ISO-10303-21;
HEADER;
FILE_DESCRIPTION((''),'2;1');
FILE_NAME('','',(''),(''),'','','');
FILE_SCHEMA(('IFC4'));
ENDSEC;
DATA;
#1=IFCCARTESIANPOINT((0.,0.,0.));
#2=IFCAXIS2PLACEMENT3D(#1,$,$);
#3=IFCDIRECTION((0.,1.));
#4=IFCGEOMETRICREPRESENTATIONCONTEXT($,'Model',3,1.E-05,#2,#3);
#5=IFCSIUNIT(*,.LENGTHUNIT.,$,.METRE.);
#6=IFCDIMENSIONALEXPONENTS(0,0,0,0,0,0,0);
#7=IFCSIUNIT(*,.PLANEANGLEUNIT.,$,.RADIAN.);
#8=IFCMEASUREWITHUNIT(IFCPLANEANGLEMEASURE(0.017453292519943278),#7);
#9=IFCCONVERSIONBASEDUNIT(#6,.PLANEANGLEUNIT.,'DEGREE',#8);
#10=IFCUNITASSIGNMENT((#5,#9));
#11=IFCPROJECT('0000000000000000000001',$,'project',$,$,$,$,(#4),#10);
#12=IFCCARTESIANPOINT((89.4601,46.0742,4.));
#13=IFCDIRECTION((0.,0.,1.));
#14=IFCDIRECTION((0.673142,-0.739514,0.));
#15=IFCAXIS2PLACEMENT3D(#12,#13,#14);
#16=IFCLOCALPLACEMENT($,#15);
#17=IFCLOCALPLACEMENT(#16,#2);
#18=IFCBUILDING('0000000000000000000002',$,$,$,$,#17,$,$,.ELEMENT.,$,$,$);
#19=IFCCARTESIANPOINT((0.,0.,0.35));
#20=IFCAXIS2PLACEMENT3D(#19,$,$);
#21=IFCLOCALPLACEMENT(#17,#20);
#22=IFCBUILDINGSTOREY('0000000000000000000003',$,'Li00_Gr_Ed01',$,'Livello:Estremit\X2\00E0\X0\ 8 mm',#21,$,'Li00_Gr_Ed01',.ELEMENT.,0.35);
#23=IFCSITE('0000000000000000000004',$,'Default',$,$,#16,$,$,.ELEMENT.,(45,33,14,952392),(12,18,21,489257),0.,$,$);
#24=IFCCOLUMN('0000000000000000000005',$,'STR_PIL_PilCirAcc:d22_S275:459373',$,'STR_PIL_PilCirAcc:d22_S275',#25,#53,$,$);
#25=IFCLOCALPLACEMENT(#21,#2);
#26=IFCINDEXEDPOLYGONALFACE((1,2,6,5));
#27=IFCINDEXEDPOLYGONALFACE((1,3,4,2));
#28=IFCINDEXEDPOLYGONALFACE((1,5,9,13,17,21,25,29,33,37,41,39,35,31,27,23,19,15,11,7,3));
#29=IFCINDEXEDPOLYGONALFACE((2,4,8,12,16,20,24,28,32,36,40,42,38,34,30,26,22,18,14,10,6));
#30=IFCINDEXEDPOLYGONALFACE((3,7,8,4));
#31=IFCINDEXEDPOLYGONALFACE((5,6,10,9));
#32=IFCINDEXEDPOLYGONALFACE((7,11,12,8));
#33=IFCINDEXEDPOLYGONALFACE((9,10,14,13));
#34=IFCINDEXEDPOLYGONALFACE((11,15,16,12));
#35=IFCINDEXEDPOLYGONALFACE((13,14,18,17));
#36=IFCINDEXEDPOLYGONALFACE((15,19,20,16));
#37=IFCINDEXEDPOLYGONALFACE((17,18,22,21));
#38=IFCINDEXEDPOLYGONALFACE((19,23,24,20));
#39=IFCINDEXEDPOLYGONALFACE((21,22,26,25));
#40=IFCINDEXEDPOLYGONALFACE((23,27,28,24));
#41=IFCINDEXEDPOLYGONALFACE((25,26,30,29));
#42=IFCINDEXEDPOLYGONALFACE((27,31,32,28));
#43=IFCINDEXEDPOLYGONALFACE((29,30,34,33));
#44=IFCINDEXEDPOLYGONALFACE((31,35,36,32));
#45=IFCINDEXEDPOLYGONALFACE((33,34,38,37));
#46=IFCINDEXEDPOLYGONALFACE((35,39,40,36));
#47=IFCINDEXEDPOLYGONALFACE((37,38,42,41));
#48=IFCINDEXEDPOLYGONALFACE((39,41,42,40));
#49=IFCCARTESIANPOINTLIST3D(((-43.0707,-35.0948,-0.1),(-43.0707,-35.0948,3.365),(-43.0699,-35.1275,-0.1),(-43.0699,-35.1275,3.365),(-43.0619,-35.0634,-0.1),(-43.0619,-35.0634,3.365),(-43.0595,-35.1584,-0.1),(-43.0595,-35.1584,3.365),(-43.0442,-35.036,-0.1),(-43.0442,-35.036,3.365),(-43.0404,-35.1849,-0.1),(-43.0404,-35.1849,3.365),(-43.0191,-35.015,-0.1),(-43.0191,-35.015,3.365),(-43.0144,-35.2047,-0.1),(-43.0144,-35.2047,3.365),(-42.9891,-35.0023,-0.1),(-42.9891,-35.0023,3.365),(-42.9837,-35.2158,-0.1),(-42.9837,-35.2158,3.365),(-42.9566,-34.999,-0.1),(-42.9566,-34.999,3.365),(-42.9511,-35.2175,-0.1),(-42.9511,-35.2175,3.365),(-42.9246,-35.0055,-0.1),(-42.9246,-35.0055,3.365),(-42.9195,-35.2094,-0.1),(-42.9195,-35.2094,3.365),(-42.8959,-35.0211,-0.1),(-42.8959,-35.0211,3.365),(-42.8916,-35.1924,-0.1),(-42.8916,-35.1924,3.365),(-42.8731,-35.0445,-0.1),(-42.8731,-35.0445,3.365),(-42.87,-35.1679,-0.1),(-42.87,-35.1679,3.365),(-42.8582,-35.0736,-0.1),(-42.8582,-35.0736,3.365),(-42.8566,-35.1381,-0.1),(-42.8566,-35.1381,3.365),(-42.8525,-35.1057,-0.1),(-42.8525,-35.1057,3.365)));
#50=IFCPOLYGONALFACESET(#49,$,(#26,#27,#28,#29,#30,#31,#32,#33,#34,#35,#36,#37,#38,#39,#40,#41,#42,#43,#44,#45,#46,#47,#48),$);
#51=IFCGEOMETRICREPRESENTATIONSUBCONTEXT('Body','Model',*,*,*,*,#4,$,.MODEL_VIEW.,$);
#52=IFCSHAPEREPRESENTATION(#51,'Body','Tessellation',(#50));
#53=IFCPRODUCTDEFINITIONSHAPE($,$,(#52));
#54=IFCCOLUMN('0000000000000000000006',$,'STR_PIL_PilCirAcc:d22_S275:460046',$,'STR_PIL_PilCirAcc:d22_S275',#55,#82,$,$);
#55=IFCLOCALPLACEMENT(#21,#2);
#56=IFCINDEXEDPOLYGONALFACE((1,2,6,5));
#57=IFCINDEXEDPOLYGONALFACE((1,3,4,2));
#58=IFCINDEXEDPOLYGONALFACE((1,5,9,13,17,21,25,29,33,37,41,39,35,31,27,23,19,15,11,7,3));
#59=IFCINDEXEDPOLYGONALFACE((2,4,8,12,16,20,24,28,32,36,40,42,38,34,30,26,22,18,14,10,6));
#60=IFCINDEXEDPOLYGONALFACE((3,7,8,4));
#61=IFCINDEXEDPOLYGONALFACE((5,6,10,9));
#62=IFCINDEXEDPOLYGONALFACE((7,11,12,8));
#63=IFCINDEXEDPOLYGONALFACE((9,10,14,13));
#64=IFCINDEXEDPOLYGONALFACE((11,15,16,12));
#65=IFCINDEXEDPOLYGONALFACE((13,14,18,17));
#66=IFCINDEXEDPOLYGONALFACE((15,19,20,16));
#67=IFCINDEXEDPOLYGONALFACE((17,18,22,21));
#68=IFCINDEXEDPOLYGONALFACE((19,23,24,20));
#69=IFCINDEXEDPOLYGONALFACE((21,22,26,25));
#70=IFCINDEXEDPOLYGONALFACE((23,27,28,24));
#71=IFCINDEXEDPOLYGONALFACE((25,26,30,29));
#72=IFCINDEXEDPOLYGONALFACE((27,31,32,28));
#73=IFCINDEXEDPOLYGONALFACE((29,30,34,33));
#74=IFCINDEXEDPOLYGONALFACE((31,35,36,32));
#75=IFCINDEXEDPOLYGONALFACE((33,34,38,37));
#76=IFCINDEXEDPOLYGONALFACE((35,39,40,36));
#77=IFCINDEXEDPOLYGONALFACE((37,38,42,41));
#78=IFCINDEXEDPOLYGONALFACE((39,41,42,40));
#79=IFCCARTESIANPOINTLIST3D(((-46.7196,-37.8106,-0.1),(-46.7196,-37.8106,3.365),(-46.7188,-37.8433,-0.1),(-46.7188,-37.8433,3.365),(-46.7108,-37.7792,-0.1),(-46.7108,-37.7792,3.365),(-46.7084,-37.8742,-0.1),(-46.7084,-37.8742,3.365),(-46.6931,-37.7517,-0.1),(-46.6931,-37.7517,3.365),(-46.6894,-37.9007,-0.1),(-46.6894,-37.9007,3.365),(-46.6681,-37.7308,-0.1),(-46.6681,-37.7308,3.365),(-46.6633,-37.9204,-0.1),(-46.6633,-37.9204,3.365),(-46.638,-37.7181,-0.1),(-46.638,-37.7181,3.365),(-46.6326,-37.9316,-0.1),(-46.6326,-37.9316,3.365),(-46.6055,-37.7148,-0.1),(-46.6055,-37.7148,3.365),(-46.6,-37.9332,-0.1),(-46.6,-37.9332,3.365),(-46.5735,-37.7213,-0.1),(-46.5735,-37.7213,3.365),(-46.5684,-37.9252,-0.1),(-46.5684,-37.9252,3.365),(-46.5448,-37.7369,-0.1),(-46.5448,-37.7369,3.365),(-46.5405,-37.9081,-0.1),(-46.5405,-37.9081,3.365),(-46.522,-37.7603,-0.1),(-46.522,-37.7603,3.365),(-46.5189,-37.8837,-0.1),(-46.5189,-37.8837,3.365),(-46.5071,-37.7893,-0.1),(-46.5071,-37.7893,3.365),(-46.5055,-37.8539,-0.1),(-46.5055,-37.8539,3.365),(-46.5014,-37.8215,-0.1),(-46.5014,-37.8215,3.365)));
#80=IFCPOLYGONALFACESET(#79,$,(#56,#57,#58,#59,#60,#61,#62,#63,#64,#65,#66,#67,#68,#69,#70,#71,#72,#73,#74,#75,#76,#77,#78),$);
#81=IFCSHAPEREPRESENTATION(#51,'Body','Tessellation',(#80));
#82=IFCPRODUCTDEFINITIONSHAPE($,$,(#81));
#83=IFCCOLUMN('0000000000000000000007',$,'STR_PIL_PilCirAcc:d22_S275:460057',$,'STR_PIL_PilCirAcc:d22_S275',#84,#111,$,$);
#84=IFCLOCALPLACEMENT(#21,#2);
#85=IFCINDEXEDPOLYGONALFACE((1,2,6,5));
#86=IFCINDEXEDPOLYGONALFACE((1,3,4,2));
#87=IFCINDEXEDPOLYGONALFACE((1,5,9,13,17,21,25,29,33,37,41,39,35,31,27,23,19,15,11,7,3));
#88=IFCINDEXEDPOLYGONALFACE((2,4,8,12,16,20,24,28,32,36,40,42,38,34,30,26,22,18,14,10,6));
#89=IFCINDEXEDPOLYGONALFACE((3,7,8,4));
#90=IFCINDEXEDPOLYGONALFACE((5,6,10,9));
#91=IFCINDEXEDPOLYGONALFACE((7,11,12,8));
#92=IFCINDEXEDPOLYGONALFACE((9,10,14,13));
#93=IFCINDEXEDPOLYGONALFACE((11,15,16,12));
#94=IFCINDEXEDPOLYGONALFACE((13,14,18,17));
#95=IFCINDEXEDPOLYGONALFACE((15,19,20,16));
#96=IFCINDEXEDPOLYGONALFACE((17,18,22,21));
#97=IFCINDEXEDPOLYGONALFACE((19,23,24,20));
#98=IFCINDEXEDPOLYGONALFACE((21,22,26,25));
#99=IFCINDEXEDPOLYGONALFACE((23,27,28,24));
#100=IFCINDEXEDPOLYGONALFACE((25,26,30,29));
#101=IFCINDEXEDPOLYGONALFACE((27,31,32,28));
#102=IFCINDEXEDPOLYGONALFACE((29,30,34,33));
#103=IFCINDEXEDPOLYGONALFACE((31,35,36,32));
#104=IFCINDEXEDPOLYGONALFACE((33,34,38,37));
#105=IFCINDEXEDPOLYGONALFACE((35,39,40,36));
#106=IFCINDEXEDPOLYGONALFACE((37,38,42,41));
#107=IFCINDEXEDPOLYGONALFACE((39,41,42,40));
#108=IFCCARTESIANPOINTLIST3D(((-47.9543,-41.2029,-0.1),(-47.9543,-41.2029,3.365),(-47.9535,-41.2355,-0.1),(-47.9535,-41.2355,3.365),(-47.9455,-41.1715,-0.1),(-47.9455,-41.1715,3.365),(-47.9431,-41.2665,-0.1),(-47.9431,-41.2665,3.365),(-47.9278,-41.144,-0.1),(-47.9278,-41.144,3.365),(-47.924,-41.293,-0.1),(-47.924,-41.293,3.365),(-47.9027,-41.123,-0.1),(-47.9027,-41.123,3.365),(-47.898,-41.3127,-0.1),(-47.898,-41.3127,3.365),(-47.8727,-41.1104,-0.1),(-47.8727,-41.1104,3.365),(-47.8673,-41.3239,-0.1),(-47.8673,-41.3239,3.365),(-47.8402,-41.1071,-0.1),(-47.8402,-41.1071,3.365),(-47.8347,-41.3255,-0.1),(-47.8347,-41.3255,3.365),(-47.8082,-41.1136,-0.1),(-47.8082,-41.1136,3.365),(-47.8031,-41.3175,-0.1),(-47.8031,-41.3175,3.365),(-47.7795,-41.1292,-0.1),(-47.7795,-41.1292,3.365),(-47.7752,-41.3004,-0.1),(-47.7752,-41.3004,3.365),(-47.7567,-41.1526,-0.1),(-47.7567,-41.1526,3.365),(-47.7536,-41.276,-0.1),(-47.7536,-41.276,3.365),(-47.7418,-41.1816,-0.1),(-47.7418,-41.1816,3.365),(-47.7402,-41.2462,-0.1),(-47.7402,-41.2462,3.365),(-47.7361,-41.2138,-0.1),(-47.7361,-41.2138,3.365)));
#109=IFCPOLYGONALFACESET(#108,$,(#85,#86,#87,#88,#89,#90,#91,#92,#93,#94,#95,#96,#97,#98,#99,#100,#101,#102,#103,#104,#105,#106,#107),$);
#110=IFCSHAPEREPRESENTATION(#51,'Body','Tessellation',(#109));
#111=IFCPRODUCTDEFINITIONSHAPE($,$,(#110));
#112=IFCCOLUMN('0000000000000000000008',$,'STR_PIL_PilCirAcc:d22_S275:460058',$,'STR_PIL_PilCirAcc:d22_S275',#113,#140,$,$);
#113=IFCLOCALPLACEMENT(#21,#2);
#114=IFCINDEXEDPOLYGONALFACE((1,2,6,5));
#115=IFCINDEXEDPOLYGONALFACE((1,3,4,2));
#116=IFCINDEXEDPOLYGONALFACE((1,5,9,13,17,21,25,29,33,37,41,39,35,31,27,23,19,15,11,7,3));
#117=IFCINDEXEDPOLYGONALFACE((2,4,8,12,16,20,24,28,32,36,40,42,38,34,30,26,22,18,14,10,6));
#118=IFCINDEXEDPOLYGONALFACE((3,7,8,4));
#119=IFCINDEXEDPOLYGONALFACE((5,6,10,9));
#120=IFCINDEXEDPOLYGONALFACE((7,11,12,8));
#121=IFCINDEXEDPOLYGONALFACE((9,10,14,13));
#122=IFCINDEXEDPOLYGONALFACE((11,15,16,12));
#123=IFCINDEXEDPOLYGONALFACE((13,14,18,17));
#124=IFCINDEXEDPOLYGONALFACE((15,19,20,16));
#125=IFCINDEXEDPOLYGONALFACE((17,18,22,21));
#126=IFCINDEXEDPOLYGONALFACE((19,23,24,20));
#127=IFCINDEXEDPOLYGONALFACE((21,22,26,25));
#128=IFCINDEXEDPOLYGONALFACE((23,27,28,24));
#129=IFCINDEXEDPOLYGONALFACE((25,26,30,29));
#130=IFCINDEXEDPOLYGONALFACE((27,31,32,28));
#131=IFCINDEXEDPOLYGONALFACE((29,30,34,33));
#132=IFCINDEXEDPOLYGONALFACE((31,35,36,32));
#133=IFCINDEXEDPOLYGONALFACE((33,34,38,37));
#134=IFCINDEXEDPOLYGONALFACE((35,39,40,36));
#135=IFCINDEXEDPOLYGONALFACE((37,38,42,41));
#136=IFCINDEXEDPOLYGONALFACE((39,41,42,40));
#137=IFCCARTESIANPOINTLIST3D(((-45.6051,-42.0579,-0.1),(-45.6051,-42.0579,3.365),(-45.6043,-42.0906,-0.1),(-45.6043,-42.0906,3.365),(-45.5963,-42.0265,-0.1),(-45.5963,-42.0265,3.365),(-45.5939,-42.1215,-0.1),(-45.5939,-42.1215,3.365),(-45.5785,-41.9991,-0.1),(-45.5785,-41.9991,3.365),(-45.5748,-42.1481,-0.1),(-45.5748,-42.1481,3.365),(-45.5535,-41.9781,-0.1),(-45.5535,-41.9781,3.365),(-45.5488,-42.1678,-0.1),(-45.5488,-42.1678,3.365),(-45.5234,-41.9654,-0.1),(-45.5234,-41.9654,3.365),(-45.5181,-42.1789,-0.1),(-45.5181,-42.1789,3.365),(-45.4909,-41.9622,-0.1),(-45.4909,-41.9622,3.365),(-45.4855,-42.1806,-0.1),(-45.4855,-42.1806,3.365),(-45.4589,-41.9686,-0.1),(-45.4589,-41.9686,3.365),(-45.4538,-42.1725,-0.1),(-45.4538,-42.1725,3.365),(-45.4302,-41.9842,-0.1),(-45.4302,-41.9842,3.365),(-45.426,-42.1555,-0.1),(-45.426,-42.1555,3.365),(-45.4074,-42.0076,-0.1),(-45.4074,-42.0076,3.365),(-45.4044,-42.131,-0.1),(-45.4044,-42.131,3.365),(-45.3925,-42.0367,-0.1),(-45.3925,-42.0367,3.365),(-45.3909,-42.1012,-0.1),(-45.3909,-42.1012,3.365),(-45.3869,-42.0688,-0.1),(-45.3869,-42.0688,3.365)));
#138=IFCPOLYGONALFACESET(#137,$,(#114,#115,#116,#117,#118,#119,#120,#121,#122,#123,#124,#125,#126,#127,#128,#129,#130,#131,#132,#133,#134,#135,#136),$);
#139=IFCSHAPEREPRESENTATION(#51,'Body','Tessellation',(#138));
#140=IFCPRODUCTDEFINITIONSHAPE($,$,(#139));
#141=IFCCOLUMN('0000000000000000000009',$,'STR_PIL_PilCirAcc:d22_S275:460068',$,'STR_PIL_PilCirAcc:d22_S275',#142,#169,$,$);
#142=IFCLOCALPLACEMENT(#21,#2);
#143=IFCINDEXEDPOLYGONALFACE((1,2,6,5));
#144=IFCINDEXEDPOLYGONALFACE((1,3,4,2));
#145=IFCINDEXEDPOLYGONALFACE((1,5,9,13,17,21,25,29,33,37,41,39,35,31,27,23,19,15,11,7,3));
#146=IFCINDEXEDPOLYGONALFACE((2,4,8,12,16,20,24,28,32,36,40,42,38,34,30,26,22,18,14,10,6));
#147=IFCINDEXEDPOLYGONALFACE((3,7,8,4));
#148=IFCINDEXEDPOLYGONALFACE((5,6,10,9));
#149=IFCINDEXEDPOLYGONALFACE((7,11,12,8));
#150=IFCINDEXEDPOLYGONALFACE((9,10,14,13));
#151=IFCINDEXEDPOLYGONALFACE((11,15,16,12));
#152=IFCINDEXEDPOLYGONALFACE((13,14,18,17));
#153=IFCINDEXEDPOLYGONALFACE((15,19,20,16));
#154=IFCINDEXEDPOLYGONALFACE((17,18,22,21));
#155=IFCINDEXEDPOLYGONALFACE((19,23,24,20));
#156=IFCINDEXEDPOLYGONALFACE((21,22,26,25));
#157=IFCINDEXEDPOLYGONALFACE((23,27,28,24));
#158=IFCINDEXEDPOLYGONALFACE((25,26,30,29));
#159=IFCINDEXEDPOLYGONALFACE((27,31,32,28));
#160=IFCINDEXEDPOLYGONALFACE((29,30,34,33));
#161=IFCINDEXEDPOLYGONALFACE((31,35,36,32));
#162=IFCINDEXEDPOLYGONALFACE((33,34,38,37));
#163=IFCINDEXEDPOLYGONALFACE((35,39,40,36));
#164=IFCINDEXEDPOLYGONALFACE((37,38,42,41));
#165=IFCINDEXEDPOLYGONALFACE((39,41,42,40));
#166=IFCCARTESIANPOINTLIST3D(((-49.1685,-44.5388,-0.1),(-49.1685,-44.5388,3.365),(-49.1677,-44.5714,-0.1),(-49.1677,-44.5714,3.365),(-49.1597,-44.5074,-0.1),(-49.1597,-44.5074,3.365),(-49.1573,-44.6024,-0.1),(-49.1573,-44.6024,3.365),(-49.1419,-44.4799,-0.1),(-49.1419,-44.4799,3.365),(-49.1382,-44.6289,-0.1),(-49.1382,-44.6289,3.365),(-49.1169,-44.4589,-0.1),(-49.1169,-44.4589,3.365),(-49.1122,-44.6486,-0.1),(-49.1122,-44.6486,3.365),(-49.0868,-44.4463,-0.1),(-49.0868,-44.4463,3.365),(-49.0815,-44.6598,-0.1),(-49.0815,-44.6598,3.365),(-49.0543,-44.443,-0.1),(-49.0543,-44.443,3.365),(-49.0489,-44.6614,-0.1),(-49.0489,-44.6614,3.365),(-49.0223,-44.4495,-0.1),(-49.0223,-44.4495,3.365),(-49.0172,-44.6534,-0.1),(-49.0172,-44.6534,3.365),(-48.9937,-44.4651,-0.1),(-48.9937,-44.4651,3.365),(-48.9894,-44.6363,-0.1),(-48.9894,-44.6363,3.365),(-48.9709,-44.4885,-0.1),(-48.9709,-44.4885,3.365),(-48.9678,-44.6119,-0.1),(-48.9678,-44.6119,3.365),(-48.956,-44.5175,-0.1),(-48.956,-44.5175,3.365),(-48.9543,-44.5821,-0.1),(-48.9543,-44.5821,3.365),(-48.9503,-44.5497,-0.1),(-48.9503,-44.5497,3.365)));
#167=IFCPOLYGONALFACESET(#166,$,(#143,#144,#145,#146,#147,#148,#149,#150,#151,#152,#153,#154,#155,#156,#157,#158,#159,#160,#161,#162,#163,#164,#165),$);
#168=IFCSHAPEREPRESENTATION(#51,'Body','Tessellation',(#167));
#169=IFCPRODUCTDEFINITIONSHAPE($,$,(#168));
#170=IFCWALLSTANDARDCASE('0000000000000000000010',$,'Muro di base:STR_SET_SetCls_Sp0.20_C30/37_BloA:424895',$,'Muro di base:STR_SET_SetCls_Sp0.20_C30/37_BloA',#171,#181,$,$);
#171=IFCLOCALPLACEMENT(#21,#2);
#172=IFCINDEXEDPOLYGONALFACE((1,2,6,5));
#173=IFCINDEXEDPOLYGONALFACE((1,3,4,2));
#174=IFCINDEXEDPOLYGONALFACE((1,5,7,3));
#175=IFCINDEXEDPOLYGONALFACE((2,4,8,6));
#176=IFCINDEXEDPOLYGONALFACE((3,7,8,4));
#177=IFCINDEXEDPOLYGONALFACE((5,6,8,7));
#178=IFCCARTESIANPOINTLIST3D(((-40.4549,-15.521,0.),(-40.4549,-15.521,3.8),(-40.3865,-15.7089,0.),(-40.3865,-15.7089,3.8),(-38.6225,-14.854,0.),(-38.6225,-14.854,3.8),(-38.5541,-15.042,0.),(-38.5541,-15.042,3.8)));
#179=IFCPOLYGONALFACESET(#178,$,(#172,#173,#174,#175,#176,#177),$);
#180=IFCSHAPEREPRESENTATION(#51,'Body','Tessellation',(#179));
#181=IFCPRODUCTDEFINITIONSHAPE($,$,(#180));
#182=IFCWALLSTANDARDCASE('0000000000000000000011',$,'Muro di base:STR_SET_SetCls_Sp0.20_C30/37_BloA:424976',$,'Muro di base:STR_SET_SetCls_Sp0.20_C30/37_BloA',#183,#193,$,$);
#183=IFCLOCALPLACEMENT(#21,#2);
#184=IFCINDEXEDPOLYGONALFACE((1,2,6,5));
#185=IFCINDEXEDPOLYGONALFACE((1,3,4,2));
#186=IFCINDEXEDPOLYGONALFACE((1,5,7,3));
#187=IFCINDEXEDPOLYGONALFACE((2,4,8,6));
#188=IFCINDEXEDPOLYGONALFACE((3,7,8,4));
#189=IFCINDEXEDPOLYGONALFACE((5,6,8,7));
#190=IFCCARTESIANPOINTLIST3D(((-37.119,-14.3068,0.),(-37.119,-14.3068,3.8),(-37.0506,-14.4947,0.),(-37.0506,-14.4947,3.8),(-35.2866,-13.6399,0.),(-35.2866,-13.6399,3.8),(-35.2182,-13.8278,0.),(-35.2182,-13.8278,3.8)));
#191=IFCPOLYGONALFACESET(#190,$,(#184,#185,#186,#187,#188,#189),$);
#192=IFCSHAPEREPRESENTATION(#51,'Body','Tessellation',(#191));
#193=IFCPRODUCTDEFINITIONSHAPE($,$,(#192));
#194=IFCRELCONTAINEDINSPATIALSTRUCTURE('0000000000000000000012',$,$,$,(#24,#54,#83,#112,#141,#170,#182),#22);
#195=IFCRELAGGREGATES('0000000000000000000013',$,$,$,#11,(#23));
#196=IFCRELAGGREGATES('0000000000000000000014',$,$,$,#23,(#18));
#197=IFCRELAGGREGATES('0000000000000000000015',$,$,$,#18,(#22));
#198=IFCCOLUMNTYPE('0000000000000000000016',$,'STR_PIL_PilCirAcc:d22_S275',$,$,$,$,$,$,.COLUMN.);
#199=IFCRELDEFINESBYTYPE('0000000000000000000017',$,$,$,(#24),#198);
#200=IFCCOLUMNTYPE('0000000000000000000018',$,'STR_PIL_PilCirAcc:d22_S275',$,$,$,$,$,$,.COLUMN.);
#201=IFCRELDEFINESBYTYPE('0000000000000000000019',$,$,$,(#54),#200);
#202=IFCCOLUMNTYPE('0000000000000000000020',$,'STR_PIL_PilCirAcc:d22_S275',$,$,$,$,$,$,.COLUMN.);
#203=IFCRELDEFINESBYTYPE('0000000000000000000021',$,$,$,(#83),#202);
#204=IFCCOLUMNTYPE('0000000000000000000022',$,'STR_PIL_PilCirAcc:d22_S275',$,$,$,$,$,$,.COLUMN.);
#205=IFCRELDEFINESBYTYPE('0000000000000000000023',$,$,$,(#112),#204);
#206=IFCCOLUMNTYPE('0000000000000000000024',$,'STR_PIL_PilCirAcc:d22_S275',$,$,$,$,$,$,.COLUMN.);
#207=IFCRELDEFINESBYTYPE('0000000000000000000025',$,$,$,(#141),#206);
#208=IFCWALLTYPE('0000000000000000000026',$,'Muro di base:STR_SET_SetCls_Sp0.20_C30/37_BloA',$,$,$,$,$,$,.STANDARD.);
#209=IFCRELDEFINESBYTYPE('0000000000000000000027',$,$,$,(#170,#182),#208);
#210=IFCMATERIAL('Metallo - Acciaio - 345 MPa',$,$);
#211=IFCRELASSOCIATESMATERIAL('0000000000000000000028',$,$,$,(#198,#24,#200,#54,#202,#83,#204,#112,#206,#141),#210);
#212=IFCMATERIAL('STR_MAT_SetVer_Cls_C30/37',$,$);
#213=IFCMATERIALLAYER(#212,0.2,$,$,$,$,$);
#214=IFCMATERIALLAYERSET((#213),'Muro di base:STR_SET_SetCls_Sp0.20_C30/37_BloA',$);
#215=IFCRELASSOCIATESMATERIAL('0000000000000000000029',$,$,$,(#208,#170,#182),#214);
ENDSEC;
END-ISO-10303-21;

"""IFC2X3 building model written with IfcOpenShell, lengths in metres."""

from ifc_helpers import new_model, entity, si_unit, converted_unit, direction, frame, frame_2d, origin, origin_2d_with_axis, place, context, subcontext, project, spatial, rectangle, circle, extrude, source, transform, mapped, material, layer, layer_set, layer_usage, type_object, type_shapes, element, save


model = new_model("IFC2X3")

# Units and contexts
model_context = context("Model", 3, precision=1e-05, world=origin(), true_north=direction((0.0, 1.0)))
body_context = subcontext(model_context, "Body", "Model", "MODEL_VIEW")
ifc_project = project(units=[si_unit("LENGTHUNIT", "METRE"), converted_unit("PLANEANGLEUNIT", "DEGREE", entity("IfcPlaneAngleMeasure", 0.017453292519943278), si_unit("PLANEANGLEUNIT", "RADIAN"), dimensions=[0, 0, 0, 0, 0, 0, 0])], contexts=[model_context])

# Site, building, storey
site_placement = place(None, frame((89.4601, 46.0742, 4.0), z_axis=(0.0, 0.0, 1.0), x_axis=(0.673142, -0.739514, 0.0)))
site = spatial("IfcSite", under=ifc_project, at=site_placement, Name="Default", CompositionType="ELEMENT", RefLatitude=(45, 33, 14, 952392), RefLongitude=(12, 18, 21, 489257), RefElevation=0.0)
building_placement = place(site_placement, origin())
building = spatial("IfcBuilding", under=site, at=building_placement, CompositionType="ELEMENT")
storey_placement = place(building_placement, frame((0.0, 0.0, 0.35)))
storey = spatial("IfcBuildingStorey", under=building, at=storey_placement, Name="Li00_Gr_Ed01", ObjectType="Livello:Estremità 8 mm", LongName="Li00_Gr_Ed01", CompositionType="ELEMENT", Elevation=0.35)

# Columns
ifc_material_1 = material(Name="Metallo - Acciaio - 345 MPa")
column_type_1 = type_object("IfcColumnType", Name="STR_PIL_PilCirAcc:d22_S275", PredefinedType="COLUMN", material=ifc_material_1)
shared_shape_1 = source(origin(), body_context, "Body", "SweptSolid", [
    extrude(circle(Radius=0.1096, at=origin_2d_with_axis()), frame((-42.962, -35.1084, 0.25), z_axis=(0.0, 0.0, 1.0), x_axis=(0.34202, 0.939693, 0.0)), (0.0, 0.0, 1.0), 3.465),
])
type_shapes(column_type_1, [shared_shape_1])
column_1_placement = place(storey_placement, frame((0.0, 0.0, -0.35)))
element("IfcColumn", 1, at=column_1_placement, inside=storey, type_object=column_type_1, material=ifc_material_1, Name="STR_PIL_PilCirAcc:d22_S275:459373", ObjectType="STR_PIL_PilCirAcc:d22_S275", context=body_context, shape_type="MappedRepresentation", body=[
    mapped(shared_shape_1, transform((0.0, 0.0, 0.0), scale=1.0)),
])
column_type_2 = type_object("IfcColumnType", Name="STR_PIL_PilCirAcc:d22_S275", PredefinedType="COLUMN", material=ifc_material_1)
shared_shape_2 = source(origin(), body_context, "Body", "SweptSolid", [
    extrude(circle(Radius=0.1096, at=origin_2d_with_axis()), frame((-46.6109, -37.8242, 0.25), z_axis=(0.0, 0.0, 1.0), x_axis=(0.34202, 0.939693, 0.0)), (0.0, 0.0, 1.0), 3.465),
])
type_shapes(column_type_2, [shared_shape_2])
column_2_placement = place(storey_placement, frame((0.0, 0.0, -0.35)))
element("IfcColumn", 2, at=column_2_placement, inside=storey, type_object=column_type_2, material=ifc_material_1, Name="STR_PIL_PilCirAcc:d22_S275:460046", ObjectType="STR_PIL_PilCirAcc:d22_S275", context=body_context, shape_type="MappedRepresentation", body=[
    mapped(shared_shape_2, transform((0.0, 0.0, 0.0), scale=1.0)),
])
column_type_3 = type_object("IfcColumnType", Name="STR_PIL_PilCirAcc:d22_S275", PredefinedType="COLUMN", material=ifc_material_1)
shared_shape_3 = source(origin(), body_context, "Body", "SweptSolid", [
    extrude(circle(Radius=0.1096, at=origin_2d_with_axis()), frame((-47.8456, -41.2165, 0.25), z_axis=(0.0, 0.0, 1.0), x_axis=(0.34202, 0.939693, 0.0)), (0.0, 0.0, 1.0), 3.465),
])
type_shapes(column_type_3, [shared_shape_3])
column_3_placement = place(storey_placement, frame((0.0, 0.0, -0.35)))
element("IfcColumn", 3, at=column_3_placement, inside=storey, type_object=column_type_3, material=ifc_material_1, Name="STR_PIL_PilCirAcc:d22_S275:460057", ObjectType="STR_PIL_PilCirAcc:d22_S275", context=body_context, shape_type="MappedRepresentation", body=[
    mapped(shared_shape_3, transform((0.0, 0.0, 0.0), scale=1.0)),
])
column_type_4 = type_object("IfcColumnType", Name="STR_PIL_PilCirAcc:d22_S275", PredefinedType="COLUMN", material=ifc_material_1)
shared_shape_4 = source(origin(), body_context, "Body", "SweptSolid", [
    extrude(circle(Radius=0.1096, at=origin_2d_with_axis()), frame((-45.4964, -42.0716, 0.25), z_axis=(0.0, 0.0, 1.0), x_axis=(0.34202, 0.939693, 0.0)), (0.0, 0.0, 1.0), 3.465),
])
type_shapes(column_type_4, [shared_shape_4])
column_4_placement = place(storey_placement, frame((0.0, 0.0, -0.35)))
element("IfcColumn", 4, at=column_4_placement, inside=storey, type_object=column_type_4, material=ifc_material_1, Name="STR_PIL_PilCirAcc:d22_S275:460058", ObjectType="STR_PIL_PilCirAcc:d22_S275", context=body_context, shape_type="MappedRepresentation", body=[
    mapped(shared_shape_4, transform((0.0, 0.0, 0.0), scale=1.0)),
])
column_type_5 = type_object("IfcColumnType", Name="STR_PIL_PilCirAcc:d22_S275", PredefinedType="COLUMN", material=ifc_material_1)
shared_shape_5 = source(origin(), body_context, "Body", "SweptSolid", [
    extrude(circle(Radius=0.1096, at=origin_2d_with_axis()), frame((-49.0598, -44.5524, 0.25), z_axis=(0.0, 0.0, 1.0), x_axis=(0.342021, 0.939692, 0.0)), (0.0, 0.0, 1.0), 3.465),
])
type_shapes(column_type_5, [shared_shape_5])
column_5_placement = place(storey_placement, frame((0.0, 0.0, -0.35)))
element("IfcColumn", 5, at=column_5_placement, inside=storey, type_object=column_type_5, material=ifc_material_1, Name="STR_PIL_PilCirAcc:d22_S275:460068", ObjectType="STR_PIL_PilCirAcc:d22_S275", context=body_context, shape_type="MappedRepresentation", body=[
    mapped(shared_shape_5, transform((0.0, 0.0, 0.0), scale=1.0)),
])

# Walls
ifc_material_2 = material(Name="STR_MAT_SetVer_Cls_C30/37")
ifc_layer_1 = layer(ifc_material_2, 0.2)
ifc_layer_set_1 = layer_set([ifc_layer_1], Name="Muro di base:STR_SET_SetCls_Sp0.20_C30/37_BloA")
ifc_layer_usage_1 = layer_usage(ifc_layer_set_1, "AXIS2", "NEGATIVE", 0.1)
wall_type_1 = type_object("IfcWallType", Name="Muro di base:STR_SET_SetCls_Sp0.20_C30/37_BloA", PredefinedType="STANDARD", material=ifc_layer_set_1)
for number, where, z_axis, x_axis, name in (
    (6, (-40.4207, -15.6149, 0.0), (0.0, 0.0, 1.0), (0.939693, 0.34202, 0.0), "Muro di base:STR_SET_SetCls_Sp0.20_C30/37_BloA:424895"),
    (7, (-37.0848, -14.4008, 0.0), (0.0, 0.0, 1.0), (0.939693, 0.34202, 0.0), "Muro di base:STR_SET_SetCls_Sp0.20_C30/37_BloA:424976"),
):
    element("IfcWallStandardCase", number, at=place(storey_placement, frame(where, z_axis=z_axis, x_axis=x_axis)), inside=storey, type_object=wall_type_1, material=ifc_layer_usage_1, Name=name, ObjectType="Muro di base:STR_SET_SetCls_Sp0.20_C30/37_BloA", context=body_context, shape_type="SweptSolid", body=[
        extrude(rectangle(XDim=1.95, YDim=0.2, at=frame_2d((0.975, 0.0), x_axis=(-1.0, 0.0))), origin(), (0.0, 0.0, 1.0), 3.8),
    ])

save(model, "model.ifc")
